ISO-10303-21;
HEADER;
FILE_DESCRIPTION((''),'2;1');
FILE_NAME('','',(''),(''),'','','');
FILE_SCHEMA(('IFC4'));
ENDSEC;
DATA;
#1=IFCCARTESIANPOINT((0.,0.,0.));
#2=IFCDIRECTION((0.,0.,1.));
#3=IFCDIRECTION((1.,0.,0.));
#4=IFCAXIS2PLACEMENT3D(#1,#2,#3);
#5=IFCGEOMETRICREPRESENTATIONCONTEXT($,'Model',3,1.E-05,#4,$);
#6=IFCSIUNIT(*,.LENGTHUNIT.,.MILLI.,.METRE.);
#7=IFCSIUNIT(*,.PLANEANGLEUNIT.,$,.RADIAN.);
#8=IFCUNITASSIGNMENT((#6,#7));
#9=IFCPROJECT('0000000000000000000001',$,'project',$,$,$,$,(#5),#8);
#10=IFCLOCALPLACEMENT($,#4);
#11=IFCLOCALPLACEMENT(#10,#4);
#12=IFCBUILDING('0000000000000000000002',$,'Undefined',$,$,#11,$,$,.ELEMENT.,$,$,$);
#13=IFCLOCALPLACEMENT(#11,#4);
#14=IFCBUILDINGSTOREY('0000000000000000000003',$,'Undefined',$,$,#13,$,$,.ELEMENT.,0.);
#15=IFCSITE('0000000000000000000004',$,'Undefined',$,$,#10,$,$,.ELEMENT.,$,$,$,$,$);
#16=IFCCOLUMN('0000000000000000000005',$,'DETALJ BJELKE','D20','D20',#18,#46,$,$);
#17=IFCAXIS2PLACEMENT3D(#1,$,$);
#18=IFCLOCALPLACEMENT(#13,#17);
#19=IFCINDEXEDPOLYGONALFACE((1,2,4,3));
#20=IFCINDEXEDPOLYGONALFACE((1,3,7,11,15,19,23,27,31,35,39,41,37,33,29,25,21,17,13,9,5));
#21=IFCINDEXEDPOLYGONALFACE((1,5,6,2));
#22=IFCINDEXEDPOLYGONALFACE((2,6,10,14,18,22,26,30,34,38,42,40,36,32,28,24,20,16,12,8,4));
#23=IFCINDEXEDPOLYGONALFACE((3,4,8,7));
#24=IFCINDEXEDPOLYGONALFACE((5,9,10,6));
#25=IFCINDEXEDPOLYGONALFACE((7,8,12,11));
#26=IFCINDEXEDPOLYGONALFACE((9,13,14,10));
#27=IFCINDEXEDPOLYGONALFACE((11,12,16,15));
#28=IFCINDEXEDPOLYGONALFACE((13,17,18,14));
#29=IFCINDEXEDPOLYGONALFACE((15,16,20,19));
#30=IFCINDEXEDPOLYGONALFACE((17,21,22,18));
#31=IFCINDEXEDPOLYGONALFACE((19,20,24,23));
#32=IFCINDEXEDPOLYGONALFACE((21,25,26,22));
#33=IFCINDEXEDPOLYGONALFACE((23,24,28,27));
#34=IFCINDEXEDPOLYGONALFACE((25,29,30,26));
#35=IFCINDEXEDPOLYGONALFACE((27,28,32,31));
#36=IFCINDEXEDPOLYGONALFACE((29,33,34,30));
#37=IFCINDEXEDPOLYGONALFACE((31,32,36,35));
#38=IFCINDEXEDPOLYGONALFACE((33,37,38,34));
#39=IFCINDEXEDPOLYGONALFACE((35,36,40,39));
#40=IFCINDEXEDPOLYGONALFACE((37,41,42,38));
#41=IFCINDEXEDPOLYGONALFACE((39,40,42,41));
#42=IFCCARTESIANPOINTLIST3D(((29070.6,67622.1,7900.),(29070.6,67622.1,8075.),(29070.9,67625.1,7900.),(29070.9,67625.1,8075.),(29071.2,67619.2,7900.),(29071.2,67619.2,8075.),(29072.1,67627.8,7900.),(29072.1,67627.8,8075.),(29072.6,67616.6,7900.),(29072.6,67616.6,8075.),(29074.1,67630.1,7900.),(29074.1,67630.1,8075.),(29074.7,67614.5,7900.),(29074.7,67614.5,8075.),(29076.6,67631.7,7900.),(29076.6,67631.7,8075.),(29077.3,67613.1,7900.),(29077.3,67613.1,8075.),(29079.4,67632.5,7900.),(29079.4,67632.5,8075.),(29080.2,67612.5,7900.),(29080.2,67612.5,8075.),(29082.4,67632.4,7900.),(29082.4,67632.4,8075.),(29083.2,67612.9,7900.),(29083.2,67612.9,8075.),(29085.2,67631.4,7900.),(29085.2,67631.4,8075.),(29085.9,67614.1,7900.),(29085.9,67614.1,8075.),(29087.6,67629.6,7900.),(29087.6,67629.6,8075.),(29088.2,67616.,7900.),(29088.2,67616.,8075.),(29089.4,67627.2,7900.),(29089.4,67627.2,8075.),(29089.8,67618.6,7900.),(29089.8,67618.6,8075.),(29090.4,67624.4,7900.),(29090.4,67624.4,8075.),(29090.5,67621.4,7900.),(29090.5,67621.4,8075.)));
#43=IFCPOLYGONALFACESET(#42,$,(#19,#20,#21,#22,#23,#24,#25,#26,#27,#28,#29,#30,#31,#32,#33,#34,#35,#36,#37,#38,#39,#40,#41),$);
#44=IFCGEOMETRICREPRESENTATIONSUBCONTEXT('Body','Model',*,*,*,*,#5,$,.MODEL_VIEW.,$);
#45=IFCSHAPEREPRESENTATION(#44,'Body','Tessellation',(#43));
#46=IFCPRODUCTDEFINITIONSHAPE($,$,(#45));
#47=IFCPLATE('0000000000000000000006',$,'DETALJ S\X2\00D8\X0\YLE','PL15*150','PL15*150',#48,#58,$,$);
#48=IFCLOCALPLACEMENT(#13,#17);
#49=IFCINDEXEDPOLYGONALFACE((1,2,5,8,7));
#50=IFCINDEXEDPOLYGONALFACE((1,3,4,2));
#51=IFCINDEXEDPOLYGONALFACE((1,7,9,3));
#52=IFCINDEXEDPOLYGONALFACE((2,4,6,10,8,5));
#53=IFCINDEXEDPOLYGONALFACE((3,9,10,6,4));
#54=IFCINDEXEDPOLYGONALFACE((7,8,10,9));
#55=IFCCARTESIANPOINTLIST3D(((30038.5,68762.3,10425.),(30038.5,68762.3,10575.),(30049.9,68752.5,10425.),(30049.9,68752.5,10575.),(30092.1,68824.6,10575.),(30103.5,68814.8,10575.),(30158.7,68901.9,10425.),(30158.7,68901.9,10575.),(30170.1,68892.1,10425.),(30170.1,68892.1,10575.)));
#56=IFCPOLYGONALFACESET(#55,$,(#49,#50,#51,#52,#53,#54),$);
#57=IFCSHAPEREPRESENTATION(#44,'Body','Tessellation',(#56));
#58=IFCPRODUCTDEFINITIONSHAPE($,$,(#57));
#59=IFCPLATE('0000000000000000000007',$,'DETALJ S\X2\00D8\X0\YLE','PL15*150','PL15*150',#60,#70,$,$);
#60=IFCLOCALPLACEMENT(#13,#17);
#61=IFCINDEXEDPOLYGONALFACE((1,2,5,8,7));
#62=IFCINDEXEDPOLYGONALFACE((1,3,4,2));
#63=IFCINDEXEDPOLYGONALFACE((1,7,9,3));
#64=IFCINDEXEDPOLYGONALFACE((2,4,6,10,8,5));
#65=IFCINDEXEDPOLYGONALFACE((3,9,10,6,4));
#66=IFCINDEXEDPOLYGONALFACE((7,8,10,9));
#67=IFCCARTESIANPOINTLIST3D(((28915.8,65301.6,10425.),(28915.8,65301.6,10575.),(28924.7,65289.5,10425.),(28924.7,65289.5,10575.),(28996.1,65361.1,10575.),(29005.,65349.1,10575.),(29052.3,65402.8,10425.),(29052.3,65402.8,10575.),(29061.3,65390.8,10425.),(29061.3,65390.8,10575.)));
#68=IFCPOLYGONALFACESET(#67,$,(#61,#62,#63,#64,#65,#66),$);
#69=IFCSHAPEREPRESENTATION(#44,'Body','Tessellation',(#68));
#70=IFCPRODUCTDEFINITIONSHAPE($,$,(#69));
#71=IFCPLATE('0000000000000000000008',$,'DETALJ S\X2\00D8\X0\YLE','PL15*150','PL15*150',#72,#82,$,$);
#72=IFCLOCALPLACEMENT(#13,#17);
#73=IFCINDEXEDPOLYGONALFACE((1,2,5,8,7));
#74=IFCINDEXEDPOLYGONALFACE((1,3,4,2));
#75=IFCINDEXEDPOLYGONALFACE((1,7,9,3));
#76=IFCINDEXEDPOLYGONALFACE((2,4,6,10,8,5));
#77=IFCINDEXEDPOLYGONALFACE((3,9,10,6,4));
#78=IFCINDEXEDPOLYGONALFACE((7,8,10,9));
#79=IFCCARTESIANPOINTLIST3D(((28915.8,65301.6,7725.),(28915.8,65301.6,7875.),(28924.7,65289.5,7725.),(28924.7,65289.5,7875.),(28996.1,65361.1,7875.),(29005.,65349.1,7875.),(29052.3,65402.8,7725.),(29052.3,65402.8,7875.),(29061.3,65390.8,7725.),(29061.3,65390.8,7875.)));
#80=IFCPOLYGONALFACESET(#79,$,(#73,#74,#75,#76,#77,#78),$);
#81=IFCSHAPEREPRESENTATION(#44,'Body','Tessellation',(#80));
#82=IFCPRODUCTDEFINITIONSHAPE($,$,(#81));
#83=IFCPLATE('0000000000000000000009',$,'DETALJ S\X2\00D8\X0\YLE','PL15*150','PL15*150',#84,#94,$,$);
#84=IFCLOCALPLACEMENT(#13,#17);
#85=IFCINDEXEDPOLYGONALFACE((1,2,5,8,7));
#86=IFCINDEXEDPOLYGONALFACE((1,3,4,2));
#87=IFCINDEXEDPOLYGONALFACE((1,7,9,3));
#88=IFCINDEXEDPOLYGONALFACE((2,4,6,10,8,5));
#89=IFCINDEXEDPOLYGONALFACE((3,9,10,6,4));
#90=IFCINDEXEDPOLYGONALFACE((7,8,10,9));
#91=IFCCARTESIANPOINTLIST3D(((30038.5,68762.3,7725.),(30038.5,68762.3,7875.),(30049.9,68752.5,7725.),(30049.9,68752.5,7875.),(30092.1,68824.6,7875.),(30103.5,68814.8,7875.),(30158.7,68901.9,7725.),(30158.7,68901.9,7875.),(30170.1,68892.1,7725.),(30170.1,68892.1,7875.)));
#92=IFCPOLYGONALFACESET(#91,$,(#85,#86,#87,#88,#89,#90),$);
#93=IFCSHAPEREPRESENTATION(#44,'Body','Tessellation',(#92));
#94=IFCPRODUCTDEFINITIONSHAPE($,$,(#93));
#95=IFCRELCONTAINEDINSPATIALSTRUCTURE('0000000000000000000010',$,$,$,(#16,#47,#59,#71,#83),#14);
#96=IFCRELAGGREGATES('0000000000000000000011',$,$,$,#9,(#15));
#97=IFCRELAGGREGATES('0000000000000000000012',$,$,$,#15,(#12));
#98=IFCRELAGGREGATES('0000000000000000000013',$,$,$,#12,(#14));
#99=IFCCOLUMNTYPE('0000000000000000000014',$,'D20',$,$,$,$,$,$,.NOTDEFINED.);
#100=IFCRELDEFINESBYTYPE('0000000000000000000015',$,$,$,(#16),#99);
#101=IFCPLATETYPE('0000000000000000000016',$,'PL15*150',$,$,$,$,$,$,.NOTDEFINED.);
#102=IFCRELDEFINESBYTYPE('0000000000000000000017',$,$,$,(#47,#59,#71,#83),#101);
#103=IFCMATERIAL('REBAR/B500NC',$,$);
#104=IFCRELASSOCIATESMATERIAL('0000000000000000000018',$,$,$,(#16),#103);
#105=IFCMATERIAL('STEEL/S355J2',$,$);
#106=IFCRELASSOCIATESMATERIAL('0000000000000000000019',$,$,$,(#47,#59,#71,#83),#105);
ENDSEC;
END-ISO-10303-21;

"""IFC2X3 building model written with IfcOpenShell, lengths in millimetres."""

from ifc_helpers import new_model, si_unit, frame, origin_with_axes, origin_2d_with_axis, place, context, subcontext, project, spatial, polyline, circle, outline, extrude, material, type_object, element, save


model = new_model("IFC2X3")

# Units and contexts
model_context = context("Model", 3, precision=1e-05, world=origin_with_axes())
body_context = subcontext(model_context, "Body", "Model", "MODEL_VIEW")
ifc_project = project(units=[si_unit("LENGTHUNIT", "METRE", prefix="MILLI"), si_unit("PLANEANGLEUNIT", "RADIAN")], contexts=[model_context])

# Site, building, storey
site_placement = place(None, origin_with_axes())
site = spatial("IfcSite", under=ifc_project, at=site_placement, Name="Undefined", CompositionType="ELEMENT")
building_placement = place(site_placement, origin_with_axes())
building = spatial("IfcBuilding", under=site, at=building_placement, Name="Undefined", CompositionType="ELEMENT")
storey_placement = place(building_placement, origin_with_axes())
storey = spatial("IfcBuildingStorey", under=building, at=storey_placement, Name="Undefined", CompositionType="ELEMENT", Elevation=0.0)

# Column
ifc_material_1 = material(Name="REBAR/B500NC")
column_type_1 = type_object("IfcColumnType", Name="D20", PredefinedType="NOTDEFINED")
for number, where, z_axis, x_axis, name in (
    (1, (29080.6, 67622.5, 7900.0), (0.0, 0.0, 1.0), (-0.595472, 0.803376, 0.0), "DETALJ BJELKE"),
):
    element("IfcColumn", number, at=place(storey_placement, frame(where, z_axis=z_axis, x_axis=x_axis)), inside=storey, type_object=column_type_1, material=ifc_material_1, Name=name, Description="D20", ObjectType="D20", context=body_context, shape_type="SweptSolid", body=[
        extrude(circle(Radius=10.0, at=origin_2d_with_axis()), frame((0.0, 0.0, 175.0), z_axis=(0.0, 0.0, -1.0), x_axis=(0.0, 1.0, 0.0)), (0.0, 0.0, 1.0), 175.0),
    ])
ifc_material_2 = material(Name="STEEL/S355J2")

# Plates
plate_type = type_object("IfcPlateType", Name="PL15*150", PredefinedType="NOTDEFINED")
plate_1_placement = place(storey_placement, frame((30097.8, 68819.7, 10575.0), z_axis=(-0.757804, 0.652483, 0.0), x_axis=(0.652483, 0.757804, 0.0)))
element("IfcPlate", 2, at=plate_1_placement, inside=storey, type_object=plate_type, material=ifc_material_2, Name="DETALJ SØYLE", Description="PL15*150", ObjectType="PL15*150", context=body_context, shape_type="SweptSolid", body=[
    extrude(outline(polyline([(0.0, 0.0), (102.0, 0.0), (102.0, 150.0), (-82.2, 150.0), (-82.2, 0.0), (0.0, 0.0)])), frame((0.0, 0.0, -7.5), z_axis=(0.0, 0.0, 1.0), x_axis=(1.0, 0.0, 0.0)), (0.0, 0.0, 1.0), 15.0),
])
for number, where, z_axis, x_axis, name in (
    (3, (29000.6, 65355.1, 10575.0), (0.595471, -0.803377, 0.0), (-0.803377, -0.595471, 0.0), "DETALJ SØYLE"),
    (4, (29000.6, 65355.1, 7875.0), (0.595471, -0.803377, 0.0), (-0.803377, -0.595471, 0.0), "DETALJ SØYLE"),
):
    element("IfcPlate", number, at=place(storey_placement, frame(where, z_axis=z_axis, x_axis=x_axis)), inside=storey, type_object=plate_type, material=ifc_material_2, Name=name, Description="PL15*150", ObjectType="PL15*150", context=body_context, shape_type="SweptSolid", body=[
        extrude(outline(polyline([(0.0, 0.0), (100.0, 0.0), (100.0, 150.0), (-70.0, 150.0), (-70.0, 0.0), (0.0, 0.0)])), frame((0.0, 0.0, -7.5), z_axis=(0.0, 0.0, 1.0), x_axis=(1.0, 0.0, 0.0)), (0.0, 0.0, 1.0), 15.0),
    ])
plate_2_placement = place(storey_placement, frame((30097.8, 68819.7, 7875.0), z_axis=(-0.757804, 0.652483, 0.0), x_axis=(0.652483, 0.757804, 0.0)))
element("IfcPlate", 5, at=plate_2_placement, inside=storey, type_object=plate_type, material=ifc_material_2, Name="DETALJ SØYLE", Description="PL15*150", ObjectType="PL15*150", context=body_context, shape_type="SweptSolid", body=[
    extrude(outline(polyline([(0.0, 0.0), (102.0, 0.0), (102.0, 150.0), (-82.2, 150.0), (-82.2, 0.0), (0.0, 0.0)])), frame((0.0, 0.0, -7.5), z_axis=(0.0, 0.0, 1.0), x_axis=(1.0, 0.0, 0.0)), (0.0, 0.0, 1.0), 15.0),
])

save(model, "model.ifc")
